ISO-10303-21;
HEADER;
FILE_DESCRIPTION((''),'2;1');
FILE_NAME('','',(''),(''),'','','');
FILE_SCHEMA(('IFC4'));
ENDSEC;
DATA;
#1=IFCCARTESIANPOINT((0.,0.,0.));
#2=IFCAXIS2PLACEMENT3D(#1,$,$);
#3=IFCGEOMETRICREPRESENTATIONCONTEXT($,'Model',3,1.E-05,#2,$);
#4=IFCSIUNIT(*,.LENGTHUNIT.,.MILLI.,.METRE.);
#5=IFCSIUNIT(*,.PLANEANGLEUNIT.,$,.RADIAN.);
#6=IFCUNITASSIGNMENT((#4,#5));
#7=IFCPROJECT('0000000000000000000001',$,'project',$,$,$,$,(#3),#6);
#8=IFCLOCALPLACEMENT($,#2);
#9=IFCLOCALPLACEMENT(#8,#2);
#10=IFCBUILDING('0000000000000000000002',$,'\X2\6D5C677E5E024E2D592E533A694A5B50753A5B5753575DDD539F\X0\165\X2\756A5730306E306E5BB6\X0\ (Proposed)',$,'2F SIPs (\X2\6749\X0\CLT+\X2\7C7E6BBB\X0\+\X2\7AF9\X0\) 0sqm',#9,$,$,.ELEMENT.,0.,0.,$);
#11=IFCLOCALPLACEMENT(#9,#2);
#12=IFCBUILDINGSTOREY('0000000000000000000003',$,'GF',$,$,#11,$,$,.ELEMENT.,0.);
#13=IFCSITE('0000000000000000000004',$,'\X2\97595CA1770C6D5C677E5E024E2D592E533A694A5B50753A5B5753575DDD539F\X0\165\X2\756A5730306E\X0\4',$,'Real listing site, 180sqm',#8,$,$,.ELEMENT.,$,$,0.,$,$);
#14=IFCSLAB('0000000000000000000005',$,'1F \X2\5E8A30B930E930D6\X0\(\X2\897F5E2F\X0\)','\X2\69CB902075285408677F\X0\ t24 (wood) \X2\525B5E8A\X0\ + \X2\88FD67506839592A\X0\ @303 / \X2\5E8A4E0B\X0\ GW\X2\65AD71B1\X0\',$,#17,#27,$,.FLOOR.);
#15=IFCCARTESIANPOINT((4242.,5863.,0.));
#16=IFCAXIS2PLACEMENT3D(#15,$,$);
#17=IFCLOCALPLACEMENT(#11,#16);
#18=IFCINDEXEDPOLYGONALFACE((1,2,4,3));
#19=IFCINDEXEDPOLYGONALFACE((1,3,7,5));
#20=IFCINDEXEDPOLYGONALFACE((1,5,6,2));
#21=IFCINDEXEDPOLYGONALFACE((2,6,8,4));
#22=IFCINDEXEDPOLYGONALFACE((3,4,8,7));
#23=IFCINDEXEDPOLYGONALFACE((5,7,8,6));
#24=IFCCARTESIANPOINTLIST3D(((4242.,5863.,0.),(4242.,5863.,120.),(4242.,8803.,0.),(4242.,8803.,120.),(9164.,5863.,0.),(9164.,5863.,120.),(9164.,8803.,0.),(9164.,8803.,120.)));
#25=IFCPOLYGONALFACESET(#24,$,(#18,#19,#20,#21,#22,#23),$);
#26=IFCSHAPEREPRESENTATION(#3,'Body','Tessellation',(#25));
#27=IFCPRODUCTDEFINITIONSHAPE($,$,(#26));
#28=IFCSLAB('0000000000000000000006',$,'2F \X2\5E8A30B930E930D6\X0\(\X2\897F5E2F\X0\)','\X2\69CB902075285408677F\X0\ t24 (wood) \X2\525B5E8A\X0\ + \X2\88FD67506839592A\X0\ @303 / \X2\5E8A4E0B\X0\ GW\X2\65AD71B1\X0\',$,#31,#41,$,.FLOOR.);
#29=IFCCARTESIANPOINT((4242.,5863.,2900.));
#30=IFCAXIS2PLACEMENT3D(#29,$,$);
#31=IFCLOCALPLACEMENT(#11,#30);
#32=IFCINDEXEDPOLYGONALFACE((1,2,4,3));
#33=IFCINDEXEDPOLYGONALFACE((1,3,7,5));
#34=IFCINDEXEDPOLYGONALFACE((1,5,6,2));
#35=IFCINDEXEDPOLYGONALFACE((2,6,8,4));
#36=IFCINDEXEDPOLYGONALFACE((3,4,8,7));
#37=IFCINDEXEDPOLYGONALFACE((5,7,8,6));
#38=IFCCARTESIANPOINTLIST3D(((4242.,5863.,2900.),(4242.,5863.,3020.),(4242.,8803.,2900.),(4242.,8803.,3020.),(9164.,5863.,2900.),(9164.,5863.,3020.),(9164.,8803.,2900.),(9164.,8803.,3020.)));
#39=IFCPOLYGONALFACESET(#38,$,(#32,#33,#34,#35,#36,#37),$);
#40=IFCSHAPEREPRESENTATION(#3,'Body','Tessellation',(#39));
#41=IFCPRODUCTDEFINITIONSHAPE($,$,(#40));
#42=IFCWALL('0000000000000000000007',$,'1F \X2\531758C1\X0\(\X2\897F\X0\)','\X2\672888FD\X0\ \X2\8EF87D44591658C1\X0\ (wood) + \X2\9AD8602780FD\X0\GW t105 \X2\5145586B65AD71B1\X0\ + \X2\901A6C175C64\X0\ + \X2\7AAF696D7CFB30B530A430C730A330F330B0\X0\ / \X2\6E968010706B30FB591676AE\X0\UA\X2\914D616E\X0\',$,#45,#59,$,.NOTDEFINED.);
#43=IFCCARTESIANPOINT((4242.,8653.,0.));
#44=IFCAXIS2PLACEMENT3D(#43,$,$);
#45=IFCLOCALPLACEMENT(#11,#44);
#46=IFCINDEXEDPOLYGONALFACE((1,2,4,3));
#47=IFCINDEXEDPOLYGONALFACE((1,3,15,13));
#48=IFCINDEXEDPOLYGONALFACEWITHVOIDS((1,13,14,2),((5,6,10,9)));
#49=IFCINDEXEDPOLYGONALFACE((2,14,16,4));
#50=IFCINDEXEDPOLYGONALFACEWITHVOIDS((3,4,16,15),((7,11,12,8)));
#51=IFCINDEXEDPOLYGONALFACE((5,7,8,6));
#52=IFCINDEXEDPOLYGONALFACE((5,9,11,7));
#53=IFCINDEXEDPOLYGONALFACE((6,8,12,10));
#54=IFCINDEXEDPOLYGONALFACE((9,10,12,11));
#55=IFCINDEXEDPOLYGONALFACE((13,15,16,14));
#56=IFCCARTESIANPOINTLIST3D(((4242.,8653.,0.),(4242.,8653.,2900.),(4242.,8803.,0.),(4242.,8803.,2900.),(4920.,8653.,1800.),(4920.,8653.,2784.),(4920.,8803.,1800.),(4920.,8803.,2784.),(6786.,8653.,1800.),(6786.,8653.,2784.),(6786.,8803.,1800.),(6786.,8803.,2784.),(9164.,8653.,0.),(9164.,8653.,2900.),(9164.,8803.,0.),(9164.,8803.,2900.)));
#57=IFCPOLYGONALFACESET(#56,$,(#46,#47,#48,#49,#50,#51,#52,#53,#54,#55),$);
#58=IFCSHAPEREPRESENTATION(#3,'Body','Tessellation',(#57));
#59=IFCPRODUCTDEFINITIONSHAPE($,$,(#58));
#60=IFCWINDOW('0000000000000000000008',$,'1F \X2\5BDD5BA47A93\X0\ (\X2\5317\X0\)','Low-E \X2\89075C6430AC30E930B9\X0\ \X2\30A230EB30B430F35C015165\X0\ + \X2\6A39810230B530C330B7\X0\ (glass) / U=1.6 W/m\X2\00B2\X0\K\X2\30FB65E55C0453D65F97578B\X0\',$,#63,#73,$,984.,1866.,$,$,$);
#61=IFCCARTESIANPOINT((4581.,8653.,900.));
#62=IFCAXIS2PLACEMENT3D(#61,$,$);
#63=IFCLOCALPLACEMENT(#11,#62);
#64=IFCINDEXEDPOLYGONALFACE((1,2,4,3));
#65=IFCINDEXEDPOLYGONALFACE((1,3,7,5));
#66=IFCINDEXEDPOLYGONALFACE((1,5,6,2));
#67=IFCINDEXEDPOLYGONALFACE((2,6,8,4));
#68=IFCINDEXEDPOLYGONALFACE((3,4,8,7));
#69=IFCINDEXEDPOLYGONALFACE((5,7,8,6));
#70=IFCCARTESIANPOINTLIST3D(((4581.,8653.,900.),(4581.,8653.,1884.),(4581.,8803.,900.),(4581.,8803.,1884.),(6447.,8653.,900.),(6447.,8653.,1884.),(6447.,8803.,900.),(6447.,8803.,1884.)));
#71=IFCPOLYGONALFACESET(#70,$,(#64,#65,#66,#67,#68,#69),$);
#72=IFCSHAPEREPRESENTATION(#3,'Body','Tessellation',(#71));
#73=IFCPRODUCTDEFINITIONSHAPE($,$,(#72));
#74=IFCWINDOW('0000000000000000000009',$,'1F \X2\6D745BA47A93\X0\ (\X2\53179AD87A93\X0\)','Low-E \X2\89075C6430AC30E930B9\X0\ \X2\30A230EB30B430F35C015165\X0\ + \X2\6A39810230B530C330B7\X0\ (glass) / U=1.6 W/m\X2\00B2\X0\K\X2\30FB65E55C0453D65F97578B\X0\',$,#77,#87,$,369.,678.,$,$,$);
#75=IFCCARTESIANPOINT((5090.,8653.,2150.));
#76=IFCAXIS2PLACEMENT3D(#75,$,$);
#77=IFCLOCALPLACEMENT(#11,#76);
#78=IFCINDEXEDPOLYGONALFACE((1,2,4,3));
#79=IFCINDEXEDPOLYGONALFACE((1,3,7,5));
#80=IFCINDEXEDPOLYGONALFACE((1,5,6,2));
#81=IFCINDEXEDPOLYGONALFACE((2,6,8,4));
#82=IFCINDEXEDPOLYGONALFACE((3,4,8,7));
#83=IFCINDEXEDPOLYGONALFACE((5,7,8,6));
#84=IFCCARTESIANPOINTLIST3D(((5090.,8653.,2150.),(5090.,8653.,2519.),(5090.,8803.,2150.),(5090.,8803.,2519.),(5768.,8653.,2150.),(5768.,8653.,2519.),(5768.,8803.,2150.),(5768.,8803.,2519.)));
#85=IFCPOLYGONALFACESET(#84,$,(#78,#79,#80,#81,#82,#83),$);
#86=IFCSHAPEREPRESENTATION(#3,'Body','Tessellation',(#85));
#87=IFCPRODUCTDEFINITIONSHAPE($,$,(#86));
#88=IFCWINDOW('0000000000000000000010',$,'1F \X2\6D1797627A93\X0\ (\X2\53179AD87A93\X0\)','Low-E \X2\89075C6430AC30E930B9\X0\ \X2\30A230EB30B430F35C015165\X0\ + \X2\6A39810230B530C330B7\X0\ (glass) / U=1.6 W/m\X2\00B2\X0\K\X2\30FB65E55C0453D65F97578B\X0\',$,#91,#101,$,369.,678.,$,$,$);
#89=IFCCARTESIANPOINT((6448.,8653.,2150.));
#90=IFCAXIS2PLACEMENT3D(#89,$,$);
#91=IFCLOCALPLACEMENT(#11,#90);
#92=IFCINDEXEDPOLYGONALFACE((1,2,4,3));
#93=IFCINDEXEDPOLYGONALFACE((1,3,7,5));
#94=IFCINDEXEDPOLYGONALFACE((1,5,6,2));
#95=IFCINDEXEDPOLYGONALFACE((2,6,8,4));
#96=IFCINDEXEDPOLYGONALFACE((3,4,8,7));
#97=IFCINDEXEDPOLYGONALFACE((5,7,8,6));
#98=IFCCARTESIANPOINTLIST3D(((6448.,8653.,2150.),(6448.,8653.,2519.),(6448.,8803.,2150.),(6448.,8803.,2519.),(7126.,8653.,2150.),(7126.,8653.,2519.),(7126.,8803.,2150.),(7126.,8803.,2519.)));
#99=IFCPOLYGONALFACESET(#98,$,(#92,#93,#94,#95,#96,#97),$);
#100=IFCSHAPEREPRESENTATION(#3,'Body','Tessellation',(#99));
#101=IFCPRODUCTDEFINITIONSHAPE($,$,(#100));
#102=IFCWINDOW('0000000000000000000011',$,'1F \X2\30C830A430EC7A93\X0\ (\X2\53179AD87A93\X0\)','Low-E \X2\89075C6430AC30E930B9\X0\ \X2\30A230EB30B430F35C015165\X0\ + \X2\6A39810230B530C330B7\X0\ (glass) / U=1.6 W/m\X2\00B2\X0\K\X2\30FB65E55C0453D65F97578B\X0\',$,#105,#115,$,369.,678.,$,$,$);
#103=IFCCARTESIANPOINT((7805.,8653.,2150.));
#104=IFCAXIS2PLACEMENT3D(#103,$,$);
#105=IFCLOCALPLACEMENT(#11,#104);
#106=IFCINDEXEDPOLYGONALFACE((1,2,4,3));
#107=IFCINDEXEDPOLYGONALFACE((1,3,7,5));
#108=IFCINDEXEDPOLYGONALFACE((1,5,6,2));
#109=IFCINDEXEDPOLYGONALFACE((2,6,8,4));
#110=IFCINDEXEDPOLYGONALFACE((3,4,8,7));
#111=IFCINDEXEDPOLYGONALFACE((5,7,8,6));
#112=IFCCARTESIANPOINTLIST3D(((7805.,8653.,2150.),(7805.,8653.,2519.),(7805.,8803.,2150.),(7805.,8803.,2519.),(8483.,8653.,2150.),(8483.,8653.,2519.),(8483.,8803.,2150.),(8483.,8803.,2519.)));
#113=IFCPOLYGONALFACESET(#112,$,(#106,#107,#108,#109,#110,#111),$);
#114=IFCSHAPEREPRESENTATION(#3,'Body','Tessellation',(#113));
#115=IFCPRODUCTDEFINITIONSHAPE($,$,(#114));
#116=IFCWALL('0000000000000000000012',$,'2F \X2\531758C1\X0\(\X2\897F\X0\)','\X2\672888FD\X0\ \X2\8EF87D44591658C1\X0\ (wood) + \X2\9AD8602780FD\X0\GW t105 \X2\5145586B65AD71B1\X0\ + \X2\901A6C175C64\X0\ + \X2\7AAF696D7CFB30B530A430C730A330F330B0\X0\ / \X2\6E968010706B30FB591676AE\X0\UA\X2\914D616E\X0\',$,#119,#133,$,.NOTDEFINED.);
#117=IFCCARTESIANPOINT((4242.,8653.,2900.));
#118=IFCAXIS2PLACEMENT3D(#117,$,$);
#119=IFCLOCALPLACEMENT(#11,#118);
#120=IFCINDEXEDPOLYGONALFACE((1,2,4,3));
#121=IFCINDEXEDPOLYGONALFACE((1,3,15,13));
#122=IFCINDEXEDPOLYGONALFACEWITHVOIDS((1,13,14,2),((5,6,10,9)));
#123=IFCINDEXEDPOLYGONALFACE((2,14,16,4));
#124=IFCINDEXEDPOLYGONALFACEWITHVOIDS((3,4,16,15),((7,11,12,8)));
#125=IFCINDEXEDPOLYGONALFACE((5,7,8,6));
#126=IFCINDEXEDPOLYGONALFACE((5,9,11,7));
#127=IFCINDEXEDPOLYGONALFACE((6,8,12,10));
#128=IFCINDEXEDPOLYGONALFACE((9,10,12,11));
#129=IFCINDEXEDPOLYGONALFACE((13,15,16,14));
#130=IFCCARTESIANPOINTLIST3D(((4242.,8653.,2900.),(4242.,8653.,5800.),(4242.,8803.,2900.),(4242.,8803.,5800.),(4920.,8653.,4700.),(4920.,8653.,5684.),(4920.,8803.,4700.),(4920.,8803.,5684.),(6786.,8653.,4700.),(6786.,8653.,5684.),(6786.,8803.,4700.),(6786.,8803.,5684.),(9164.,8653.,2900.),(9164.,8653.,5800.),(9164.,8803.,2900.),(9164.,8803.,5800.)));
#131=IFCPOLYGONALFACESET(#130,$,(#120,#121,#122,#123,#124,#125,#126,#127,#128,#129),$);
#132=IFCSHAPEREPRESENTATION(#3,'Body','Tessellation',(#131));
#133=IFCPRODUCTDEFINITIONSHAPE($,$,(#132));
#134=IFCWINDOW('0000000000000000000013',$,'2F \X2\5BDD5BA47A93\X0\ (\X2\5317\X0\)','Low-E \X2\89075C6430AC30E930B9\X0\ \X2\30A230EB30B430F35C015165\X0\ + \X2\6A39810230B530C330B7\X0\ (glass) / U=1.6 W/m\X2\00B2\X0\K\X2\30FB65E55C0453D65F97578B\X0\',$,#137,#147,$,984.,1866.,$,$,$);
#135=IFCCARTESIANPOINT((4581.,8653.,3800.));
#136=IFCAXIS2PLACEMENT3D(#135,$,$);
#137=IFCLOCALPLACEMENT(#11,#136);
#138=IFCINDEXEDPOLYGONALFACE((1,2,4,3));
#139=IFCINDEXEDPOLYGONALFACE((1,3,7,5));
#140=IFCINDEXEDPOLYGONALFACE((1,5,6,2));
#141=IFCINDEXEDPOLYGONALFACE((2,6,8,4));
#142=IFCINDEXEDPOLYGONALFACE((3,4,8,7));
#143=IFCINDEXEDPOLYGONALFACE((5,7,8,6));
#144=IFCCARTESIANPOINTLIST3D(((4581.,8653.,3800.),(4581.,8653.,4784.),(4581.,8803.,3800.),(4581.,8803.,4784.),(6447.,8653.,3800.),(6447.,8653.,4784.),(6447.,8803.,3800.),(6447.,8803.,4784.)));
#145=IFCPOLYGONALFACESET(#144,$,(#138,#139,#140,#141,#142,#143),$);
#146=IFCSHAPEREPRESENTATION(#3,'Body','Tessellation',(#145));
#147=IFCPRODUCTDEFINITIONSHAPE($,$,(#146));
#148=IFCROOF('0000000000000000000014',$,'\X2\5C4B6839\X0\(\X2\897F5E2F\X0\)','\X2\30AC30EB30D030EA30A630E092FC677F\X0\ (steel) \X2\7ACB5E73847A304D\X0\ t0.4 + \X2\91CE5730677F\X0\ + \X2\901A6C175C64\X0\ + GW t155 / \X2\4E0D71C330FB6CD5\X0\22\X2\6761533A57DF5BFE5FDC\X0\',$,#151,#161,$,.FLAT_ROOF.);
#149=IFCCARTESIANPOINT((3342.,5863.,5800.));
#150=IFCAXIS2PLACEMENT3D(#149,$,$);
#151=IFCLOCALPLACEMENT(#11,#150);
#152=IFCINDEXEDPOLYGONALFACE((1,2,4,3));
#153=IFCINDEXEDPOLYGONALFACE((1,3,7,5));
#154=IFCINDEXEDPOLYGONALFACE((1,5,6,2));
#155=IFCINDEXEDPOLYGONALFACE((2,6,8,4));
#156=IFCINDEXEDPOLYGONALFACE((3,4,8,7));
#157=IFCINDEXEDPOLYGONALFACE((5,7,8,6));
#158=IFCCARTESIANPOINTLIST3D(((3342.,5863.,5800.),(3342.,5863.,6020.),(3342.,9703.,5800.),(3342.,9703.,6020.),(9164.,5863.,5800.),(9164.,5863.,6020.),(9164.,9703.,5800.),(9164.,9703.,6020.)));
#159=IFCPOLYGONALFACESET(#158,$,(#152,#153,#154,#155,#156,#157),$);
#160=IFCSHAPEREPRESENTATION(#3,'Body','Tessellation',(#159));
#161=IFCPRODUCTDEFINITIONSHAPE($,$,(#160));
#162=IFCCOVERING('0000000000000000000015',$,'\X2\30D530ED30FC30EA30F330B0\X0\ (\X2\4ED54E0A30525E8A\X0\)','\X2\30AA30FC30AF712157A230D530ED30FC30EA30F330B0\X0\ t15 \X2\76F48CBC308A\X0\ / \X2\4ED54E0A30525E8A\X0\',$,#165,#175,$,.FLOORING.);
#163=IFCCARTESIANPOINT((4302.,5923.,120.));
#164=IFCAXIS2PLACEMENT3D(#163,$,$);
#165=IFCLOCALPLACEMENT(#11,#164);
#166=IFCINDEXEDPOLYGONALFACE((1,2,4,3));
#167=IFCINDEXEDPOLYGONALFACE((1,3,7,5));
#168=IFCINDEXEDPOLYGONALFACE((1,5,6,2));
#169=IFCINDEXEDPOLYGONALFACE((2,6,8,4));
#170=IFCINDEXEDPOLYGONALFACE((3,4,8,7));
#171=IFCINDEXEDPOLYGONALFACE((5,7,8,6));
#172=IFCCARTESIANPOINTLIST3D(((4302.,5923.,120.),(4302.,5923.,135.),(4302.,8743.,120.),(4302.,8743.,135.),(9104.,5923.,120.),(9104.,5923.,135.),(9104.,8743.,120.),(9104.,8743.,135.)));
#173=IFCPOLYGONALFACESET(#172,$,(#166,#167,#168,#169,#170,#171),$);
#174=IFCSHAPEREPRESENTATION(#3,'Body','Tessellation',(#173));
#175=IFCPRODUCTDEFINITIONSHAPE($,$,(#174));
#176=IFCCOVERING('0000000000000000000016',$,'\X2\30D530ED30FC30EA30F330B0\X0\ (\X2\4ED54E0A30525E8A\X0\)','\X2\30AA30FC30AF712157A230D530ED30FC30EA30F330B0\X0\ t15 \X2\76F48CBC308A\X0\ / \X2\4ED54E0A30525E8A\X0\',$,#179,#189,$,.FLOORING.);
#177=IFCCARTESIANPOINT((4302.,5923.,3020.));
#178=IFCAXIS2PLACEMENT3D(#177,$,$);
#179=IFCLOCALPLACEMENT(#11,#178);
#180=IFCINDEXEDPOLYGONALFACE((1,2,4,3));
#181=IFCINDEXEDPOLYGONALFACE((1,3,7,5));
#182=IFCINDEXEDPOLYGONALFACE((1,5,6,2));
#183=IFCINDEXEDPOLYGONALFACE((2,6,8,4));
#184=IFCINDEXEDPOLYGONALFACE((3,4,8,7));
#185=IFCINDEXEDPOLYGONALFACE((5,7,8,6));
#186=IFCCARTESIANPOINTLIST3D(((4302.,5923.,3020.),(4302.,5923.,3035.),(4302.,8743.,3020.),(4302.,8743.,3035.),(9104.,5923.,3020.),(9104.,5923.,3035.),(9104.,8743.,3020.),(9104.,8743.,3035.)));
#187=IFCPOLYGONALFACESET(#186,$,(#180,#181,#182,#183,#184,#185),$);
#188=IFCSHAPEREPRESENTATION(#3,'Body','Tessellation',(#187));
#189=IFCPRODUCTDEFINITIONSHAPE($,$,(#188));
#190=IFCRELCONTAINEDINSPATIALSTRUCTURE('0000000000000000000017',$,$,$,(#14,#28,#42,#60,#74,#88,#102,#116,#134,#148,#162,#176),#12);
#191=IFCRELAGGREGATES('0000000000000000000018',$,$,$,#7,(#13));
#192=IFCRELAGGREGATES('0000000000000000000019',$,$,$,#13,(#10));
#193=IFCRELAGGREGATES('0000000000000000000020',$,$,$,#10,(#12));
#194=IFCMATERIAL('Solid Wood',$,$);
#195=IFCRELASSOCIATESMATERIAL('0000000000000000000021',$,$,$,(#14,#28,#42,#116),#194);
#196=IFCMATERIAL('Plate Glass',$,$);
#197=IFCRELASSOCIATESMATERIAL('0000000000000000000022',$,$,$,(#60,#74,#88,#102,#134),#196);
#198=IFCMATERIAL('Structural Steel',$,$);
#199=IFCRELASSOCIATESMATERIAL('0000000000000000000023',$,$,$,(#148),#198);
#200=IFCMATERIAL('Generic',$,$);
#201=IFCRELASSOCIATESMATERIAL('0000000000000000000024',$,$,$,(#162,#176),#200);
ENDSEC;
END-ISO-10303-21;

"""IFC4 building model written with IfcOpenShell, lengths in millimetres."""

from ifc_helpers import new_model, si_unit, frame, frame_2d, origin, place, context, project, spatial, rectangle, extrude, material, element, fill, save


model = new_model("IFC4")

# Units and contexts
model_context = context("Model", 3, precision=1e-05, world=origin())
ifc_project = project(units=[si_unit("LENGTHUNIT", "METRE", prefix="MILLI"), si_unit("PLANEANGLEUNIT", "RADIAN")], contexts=[model_context])

# Site, building, storey
site_placement = place(None, origin())
site = spatial("IfcSite", under=ifc_project, at=site_placement, Name="静岡県浜松市中央区楊子町字南川原165番地の4", ObjectType="Real listing site, 180sqm", CompositionType="ELEMENT", RefElevation=0.0)
building_placement = place(site_placement, origin())
building = spatial("IfcBuilding", under=site, at=building_placement, Name="浜松市中央区楊子町字南川原165番地のの家 (Proposed)", ObjectType="2F SIPs (杉CLT+籾殻+竹) 0sqm", CompositionType="ELEMENT", ElevationOfRefHeight=0.0, ElevationOfTerrain=0.0)
storey_placement = place(building_placement, origin())
storey = spatial("IfcBuildingStorey", under=building, at=storey_placement, Name="GF", CompositionType="ELEMENT", Elevation=0.0)

# Slabs
ifc_material_1 = material(Name="Solid Wood")
slab_1_placement = place(storey_placement, frame((4242.0, 5863.0, 0.0)))
element("IfcSlab", 1, at=slab_1_placement, inside=storey, material=ifc_material_1, Name="1F 床スラブ(西帯)", Description="構造用合板 t24 (wood) 剛床 + 製材根太 @303 / 床下 GW断熱", PredefinedType="FLOOR", context=model_context, shape_type="SweptSolid", body=[
    extrude(rectangle(XDim=4922.0, YDim=2940.0, at=frame_2d((2461.0, 1470.0))), frame((4242.0, 5863.0, 0.0)), (0.0, 0.0, 1.0), 120.0),
])
slab_2_placement = place(storey_placement, frame((4242.0, 5863.0, 2900.0)))
element("IfcSlab", 2, at=slab_2_placement, inside=storey, material=ifc_material_1, Name="2F 床スラブ(西帯)", Description="構造用合板 t24 (wood) 剛床 + 製材根太 @303 / 床下 GW断熱", PredefinedType="FLOOR", context=model_context, shape_type="SweptSolid", body=[
    extrude(rectangle(XDim=4922.0, YDim=2940.0, at=frame_2d((2461.0, 1470.0))), frame((4242.0, 5863.0, 2900.0)), (0.0, 0.0, 1.0), 120.0),
])

# Wall, openings, windows
wall_1_placement = place(storey_placement, frame((4242.0, 8653.0, 0.0)))
wall_1 = element("IfcWall", 3, at=wall_1_placement, inside=storey, material=ifc_material_1, Name="1F 北壁(西)", Description="木製 軸組外壁 (wood) + 高性能GW t105 充填断熱 + 通気層 + 窯業系サイディング / 準耐火・外皮UA配慮", PredefinedType="NOTDEFINED", context=model_context, shape_type="SweptSolid", body=[
    extrude(rectangle(XDim=4922.0, YDim=150.0, at=frame_2d((2461.0, 75.0))), frame((4242.0, 8653.0, 0.0)), (0.0, 0.0, 1.0), 2900.0),
])
opening_1_placement = place(storey_placement, frame((4581.0, 8653.0, 900.0)))
opening_1 = element("IfcOpeningElement", 4, at=opening_1_placement, cuts=wall_1, PredefinedType="NOTDEFINED", context=model_context, shape_type="SweptSolid", body=[
    extrude(rectangle(XDim=1866.0, YDim=150.0, at=frame_2d((933.0, 75.0))), frame((4581.0, 8653.0, 900.0)), (0.0, 0.0, 1.0), 984.0),
])
opening_2_placement = place(storey_placement, frame((5090.0, 8653.0, 2150.0)))
opening_2 = element("IfcOpeningElement", 5, at=opening_2_placement, cuts=wall_1, PredefinedType="NOTDEFINED", context=model_context, shape_type="SweptSolid", body=[
    extrude(rectangle(XDim=678.0, YDim=150.0, at=frame_2d((339.0, 75.0))), frame((5090.0, 8653.0, 2150.0)), (0.0, 0.0, 1.0), 369.0),
])
opening_3_placement = place(storey_placement, frame((6448.0, 8653.0, 2150.0)))
opening_3 = element("IfcOpeningElement", 6, at=opening_3_placement, cuts=wall_1, PredefinedType="NOTDEFINED", context=model_context, shape_type="SweptSolid", body=[
    extrude(rectangle(XDim=678.0, YDim=150.0, at=frame_2d((339.0, 75.0))), frame((6448.0, 8653.0, 2150.0)), (0.0, 0.0, 1.0), 369.0),
])
opening_4_placement = place(storey_placement, frame((7805.0, 8653.0, 2150.0)))
opening_4 = element("IfcOpeningElement", 7, at=opening_4_placement, cuts=wall_1, PredefinedType="NOTDEFINED", context=model_context, shape_type="SweptSolid", body=[
    extrude(rectangle(XDim=678.0, YDim=150.0, at=frame_2d((339.0, 75.0))), frame((7805.0, 8653.0, 2150.0)), (0.0, 0.0, 1.0), 369.0),
])
ifc_material_2 = material(Name="Plate Glass")
window_1_placement = place(storey_placement, frame((4581.0, 8653.0, 900.0)))
window_1 = element("IfcWindow", 8, at=window_1_placement, inside=storey, material=ifc_material_2, Name="1F 寝室窓 (北)", Description="Low-E 複層ガラス アルゴン封入 + 樹脂サッシ (glass) / U=1.6 W/m²K・日射取得型", OverallHeight=984.0, OverallWidth=1866.0, context=model_context, shape_type="SweptSolid", body=[
    extrude(rectangle(XDim=1866.0, YDim=150.0, at=frame_2d((933.0, 75.0))), frame((4581.0, 8653.0, 900.0)), (0.0, 0.0, 1.0), 984.0),
])
fill(opening_1, window_1)
window_2_placement = place(storey_placement, frame((5090.0, 8653.0, 2150.0)))
window_2 = element("IfcWindow", 9, at=window_2_placement, inside=storey, material=ifc_material_2, Name="1F 浴室窓 (北高窓)", Description="Low-E 複層ガラス アルゴン封入 + 樹脂サッシ (glass) / U=1.6 W/m²K・日射取得型", OverallHeight=369.0, OverallWidth=678.0, context=model_context, shape_type="SweptSolid", body=[
    extrude(rectangle(XDim=678.0, YDim=150.0, at=frame_2d((339.0, 75.0))), frame((5090.0, 8653.0, 2150.0)), (0.0, 0.0, 1.0), 369.0),
])
fill(opening_2, window_2)
window_3_placement = place(storey_placement, frame((6448.0, 8653.0, 2150.0)))
window_3 = element("IfcWindow", 10, at=window_3_placement, inside=storey, material=ifc_material_2, Name="1F 洗面窓 (北高窓)", Description="Low-E 複層ガラス アルゴン封入 + 樹脂サッシ (glass) / U=1.6 W/m²K・日射取得型", OverallHeight=369.0, OverallWidth=678.0, context=model_context, shape_type="SweptSolid", body=[
    extrude(rectangle(XDim=678.0, YDim=150.0, at=frame_2d((339.0, 75.0))), frame((6448.0, 8653.0, 2150.0)), (0.0, 0.0, 1.0), 369.0),
])
fill(opening_3, window_3)
window_4_placement = place(storey_placement, frame((7805.0, 8653.0, 2150.0)))
window_4 = element("IfcWindow", 11, at=window_4_placement, inside=storey, material=ifc_material_2, Name="1F トイレ窓 (北高窓)", Description="Low-E 複層ガラス アルゴン封入 + 樹脂サッシ (glass) / U=1.6 W/m²K・日射取得型", OverallHeight=369.0, OverallWidth=678.0, context=model_context, shape_type="SweptSolid", body=[
    extrude(rectangle(XDim=678.0, YDim=150.0, at=frame_2d((339.0, 75.0))), frame((7805.0, 8653.0, 2150.0)), (0.0, 0.0, 1.0), 369.0),
])
fill(opening_4, window_4)

# Wall, opening, window
wall_2_placement = place(storey_placement, frame((4242.0, 8653.0, 2900.0)))
wall_2 = element("IfcWall", 12, at=wall_2_placement, inside=storey, material=ifc_material_1, Name="2F 北壁(西)", Description="木製 軸組外壁 (wood) + 高性能GW t105 充填断熱 + 通気層 + 窯業系サイディング / 準耐火・外皮UA配慮", PredefinedType="NOTDEFINED", context=model_context, shape_type="SweptSolid", body=[
    extrude(rectangle(XDim=4922.0, YDim=150.0, at=frame_2d((2461.0, 75.0))), frame((4242.0, 8653.0, 2900.0)), (0.0, 0.0, 1.0), 2900.0),
])
opening_5_placement = place(storey_placement, frame((4581.0, 8653.0, 3800.0)))
opening_5 = element("IfcOpeningElement", 13, at=opening_5_placement, cuts=wall_2, PredefinedType="NOTDEFINED", context=model_context, shape_type="SweptSolid", body=[
    extrude(rectangle(XDim=1866.0, YDim=150.0, at=frame_2d((933.0, 75.0))), frame((4581.0, 8653.0, 3800.0)), (0.0, 0.0, 1.0), 984.0),
])
window_5_placement = place(storey_placement, frame((4581.0, 8653.0, 3800.0)))
window_5 = element("IfcWindow", 14, at=window_5_placement, inside=storey, material=ifc_material_2, Name="2F 寝室窓 (北)", Description="Low-E 複層ガラス アルゴン封入 + 樹脂サッシ (glass) / U=1.6 W/m²K・日射取得型", OverallHeight=984.0, OverallWidth=1866.0, context=model_context, shape_type="SweptSolid", body=[
    extrude(rectangle(XDim=1866.0, YDim=150.0, at=frame_2d((933.0, 75.0))), frame((4581.0, 8653.0, 3800.0)), (0.0, 0.0, 1.0), 984.0),
])
fill(opening_5, window_5)

# Roof
ifc_material_3 = material(Name="Structural Steel")
for number, where, name in (
    (15, (3342.0, 5863.0, 5800.0), "屋根(西帯)"),
):
    element("IfcRoof", number, at=place(storey_placement, frame(where)), inside=storey, material=ifc_material_3, Name=name, Description="ガルバリウム鋼板 (steel) 立平葺き t0.4 + 野地板 + 通気層 + GW t155 / 不燃・法22条区域対応", PredefinedType="FLAT_ROOF", context=model_context, shape_type="SweptSolid", body=[
        extrude(rectangle(XDim=5822.0, YDim=3840.0, at=frame_2d((2911.0, 1920.0))), frame((3342.0, 5863.0, 5800.0)), (0.0, 0.0, 1.0), 220.0),
    ])

# Coverings
ifc_material_4 = material(Name="Generic")
covering_1_placement = place(storey_placement, frame((4302.0, 5923.0, 120.0)))
element("IfcCovering", 16, at=covering_1_placement, inside=storey, material=ifc_material_4, Name="フローリング (仕上げ床)", Description="オーク無垢フローリング t15 直貼り / 仕上げ床", PredefinedType="FLOORING", context=model_context, shape_type="SweptSolid", body=[
    extrude(rectangle(XDim=4802.0, YDim=2820.0, at=frame_2d((2401.0, 1410.0))), frame((4302.0, 5923.0, 120.0)), (0.0, 0.0, 1.0), 15.0),
])
covering_2_placement = place(storey_placement, frame((4302.0, 5923.0, 3020.0)))
element("IfcCovering", 17, at=covering_2_placement, inside=storey, material=ifc_material_4, Name="フローリング (仕上げ床)", Description="オーク無垢フローリング t15 直貼り / 仕上げ床", PredefinedType="FLOORING", context=model_context, shape_type="SweptSolid", body=[
    extrude(rectangle(XDim=4802.0, YDim=2820.0, at=frame_2d((2401.0, 1410.0))), frame((4302.0, 5923.0, 3020.0)), (0.0, 0.0, 1.0), 15.0),
])

save(model, "model.ifc")
